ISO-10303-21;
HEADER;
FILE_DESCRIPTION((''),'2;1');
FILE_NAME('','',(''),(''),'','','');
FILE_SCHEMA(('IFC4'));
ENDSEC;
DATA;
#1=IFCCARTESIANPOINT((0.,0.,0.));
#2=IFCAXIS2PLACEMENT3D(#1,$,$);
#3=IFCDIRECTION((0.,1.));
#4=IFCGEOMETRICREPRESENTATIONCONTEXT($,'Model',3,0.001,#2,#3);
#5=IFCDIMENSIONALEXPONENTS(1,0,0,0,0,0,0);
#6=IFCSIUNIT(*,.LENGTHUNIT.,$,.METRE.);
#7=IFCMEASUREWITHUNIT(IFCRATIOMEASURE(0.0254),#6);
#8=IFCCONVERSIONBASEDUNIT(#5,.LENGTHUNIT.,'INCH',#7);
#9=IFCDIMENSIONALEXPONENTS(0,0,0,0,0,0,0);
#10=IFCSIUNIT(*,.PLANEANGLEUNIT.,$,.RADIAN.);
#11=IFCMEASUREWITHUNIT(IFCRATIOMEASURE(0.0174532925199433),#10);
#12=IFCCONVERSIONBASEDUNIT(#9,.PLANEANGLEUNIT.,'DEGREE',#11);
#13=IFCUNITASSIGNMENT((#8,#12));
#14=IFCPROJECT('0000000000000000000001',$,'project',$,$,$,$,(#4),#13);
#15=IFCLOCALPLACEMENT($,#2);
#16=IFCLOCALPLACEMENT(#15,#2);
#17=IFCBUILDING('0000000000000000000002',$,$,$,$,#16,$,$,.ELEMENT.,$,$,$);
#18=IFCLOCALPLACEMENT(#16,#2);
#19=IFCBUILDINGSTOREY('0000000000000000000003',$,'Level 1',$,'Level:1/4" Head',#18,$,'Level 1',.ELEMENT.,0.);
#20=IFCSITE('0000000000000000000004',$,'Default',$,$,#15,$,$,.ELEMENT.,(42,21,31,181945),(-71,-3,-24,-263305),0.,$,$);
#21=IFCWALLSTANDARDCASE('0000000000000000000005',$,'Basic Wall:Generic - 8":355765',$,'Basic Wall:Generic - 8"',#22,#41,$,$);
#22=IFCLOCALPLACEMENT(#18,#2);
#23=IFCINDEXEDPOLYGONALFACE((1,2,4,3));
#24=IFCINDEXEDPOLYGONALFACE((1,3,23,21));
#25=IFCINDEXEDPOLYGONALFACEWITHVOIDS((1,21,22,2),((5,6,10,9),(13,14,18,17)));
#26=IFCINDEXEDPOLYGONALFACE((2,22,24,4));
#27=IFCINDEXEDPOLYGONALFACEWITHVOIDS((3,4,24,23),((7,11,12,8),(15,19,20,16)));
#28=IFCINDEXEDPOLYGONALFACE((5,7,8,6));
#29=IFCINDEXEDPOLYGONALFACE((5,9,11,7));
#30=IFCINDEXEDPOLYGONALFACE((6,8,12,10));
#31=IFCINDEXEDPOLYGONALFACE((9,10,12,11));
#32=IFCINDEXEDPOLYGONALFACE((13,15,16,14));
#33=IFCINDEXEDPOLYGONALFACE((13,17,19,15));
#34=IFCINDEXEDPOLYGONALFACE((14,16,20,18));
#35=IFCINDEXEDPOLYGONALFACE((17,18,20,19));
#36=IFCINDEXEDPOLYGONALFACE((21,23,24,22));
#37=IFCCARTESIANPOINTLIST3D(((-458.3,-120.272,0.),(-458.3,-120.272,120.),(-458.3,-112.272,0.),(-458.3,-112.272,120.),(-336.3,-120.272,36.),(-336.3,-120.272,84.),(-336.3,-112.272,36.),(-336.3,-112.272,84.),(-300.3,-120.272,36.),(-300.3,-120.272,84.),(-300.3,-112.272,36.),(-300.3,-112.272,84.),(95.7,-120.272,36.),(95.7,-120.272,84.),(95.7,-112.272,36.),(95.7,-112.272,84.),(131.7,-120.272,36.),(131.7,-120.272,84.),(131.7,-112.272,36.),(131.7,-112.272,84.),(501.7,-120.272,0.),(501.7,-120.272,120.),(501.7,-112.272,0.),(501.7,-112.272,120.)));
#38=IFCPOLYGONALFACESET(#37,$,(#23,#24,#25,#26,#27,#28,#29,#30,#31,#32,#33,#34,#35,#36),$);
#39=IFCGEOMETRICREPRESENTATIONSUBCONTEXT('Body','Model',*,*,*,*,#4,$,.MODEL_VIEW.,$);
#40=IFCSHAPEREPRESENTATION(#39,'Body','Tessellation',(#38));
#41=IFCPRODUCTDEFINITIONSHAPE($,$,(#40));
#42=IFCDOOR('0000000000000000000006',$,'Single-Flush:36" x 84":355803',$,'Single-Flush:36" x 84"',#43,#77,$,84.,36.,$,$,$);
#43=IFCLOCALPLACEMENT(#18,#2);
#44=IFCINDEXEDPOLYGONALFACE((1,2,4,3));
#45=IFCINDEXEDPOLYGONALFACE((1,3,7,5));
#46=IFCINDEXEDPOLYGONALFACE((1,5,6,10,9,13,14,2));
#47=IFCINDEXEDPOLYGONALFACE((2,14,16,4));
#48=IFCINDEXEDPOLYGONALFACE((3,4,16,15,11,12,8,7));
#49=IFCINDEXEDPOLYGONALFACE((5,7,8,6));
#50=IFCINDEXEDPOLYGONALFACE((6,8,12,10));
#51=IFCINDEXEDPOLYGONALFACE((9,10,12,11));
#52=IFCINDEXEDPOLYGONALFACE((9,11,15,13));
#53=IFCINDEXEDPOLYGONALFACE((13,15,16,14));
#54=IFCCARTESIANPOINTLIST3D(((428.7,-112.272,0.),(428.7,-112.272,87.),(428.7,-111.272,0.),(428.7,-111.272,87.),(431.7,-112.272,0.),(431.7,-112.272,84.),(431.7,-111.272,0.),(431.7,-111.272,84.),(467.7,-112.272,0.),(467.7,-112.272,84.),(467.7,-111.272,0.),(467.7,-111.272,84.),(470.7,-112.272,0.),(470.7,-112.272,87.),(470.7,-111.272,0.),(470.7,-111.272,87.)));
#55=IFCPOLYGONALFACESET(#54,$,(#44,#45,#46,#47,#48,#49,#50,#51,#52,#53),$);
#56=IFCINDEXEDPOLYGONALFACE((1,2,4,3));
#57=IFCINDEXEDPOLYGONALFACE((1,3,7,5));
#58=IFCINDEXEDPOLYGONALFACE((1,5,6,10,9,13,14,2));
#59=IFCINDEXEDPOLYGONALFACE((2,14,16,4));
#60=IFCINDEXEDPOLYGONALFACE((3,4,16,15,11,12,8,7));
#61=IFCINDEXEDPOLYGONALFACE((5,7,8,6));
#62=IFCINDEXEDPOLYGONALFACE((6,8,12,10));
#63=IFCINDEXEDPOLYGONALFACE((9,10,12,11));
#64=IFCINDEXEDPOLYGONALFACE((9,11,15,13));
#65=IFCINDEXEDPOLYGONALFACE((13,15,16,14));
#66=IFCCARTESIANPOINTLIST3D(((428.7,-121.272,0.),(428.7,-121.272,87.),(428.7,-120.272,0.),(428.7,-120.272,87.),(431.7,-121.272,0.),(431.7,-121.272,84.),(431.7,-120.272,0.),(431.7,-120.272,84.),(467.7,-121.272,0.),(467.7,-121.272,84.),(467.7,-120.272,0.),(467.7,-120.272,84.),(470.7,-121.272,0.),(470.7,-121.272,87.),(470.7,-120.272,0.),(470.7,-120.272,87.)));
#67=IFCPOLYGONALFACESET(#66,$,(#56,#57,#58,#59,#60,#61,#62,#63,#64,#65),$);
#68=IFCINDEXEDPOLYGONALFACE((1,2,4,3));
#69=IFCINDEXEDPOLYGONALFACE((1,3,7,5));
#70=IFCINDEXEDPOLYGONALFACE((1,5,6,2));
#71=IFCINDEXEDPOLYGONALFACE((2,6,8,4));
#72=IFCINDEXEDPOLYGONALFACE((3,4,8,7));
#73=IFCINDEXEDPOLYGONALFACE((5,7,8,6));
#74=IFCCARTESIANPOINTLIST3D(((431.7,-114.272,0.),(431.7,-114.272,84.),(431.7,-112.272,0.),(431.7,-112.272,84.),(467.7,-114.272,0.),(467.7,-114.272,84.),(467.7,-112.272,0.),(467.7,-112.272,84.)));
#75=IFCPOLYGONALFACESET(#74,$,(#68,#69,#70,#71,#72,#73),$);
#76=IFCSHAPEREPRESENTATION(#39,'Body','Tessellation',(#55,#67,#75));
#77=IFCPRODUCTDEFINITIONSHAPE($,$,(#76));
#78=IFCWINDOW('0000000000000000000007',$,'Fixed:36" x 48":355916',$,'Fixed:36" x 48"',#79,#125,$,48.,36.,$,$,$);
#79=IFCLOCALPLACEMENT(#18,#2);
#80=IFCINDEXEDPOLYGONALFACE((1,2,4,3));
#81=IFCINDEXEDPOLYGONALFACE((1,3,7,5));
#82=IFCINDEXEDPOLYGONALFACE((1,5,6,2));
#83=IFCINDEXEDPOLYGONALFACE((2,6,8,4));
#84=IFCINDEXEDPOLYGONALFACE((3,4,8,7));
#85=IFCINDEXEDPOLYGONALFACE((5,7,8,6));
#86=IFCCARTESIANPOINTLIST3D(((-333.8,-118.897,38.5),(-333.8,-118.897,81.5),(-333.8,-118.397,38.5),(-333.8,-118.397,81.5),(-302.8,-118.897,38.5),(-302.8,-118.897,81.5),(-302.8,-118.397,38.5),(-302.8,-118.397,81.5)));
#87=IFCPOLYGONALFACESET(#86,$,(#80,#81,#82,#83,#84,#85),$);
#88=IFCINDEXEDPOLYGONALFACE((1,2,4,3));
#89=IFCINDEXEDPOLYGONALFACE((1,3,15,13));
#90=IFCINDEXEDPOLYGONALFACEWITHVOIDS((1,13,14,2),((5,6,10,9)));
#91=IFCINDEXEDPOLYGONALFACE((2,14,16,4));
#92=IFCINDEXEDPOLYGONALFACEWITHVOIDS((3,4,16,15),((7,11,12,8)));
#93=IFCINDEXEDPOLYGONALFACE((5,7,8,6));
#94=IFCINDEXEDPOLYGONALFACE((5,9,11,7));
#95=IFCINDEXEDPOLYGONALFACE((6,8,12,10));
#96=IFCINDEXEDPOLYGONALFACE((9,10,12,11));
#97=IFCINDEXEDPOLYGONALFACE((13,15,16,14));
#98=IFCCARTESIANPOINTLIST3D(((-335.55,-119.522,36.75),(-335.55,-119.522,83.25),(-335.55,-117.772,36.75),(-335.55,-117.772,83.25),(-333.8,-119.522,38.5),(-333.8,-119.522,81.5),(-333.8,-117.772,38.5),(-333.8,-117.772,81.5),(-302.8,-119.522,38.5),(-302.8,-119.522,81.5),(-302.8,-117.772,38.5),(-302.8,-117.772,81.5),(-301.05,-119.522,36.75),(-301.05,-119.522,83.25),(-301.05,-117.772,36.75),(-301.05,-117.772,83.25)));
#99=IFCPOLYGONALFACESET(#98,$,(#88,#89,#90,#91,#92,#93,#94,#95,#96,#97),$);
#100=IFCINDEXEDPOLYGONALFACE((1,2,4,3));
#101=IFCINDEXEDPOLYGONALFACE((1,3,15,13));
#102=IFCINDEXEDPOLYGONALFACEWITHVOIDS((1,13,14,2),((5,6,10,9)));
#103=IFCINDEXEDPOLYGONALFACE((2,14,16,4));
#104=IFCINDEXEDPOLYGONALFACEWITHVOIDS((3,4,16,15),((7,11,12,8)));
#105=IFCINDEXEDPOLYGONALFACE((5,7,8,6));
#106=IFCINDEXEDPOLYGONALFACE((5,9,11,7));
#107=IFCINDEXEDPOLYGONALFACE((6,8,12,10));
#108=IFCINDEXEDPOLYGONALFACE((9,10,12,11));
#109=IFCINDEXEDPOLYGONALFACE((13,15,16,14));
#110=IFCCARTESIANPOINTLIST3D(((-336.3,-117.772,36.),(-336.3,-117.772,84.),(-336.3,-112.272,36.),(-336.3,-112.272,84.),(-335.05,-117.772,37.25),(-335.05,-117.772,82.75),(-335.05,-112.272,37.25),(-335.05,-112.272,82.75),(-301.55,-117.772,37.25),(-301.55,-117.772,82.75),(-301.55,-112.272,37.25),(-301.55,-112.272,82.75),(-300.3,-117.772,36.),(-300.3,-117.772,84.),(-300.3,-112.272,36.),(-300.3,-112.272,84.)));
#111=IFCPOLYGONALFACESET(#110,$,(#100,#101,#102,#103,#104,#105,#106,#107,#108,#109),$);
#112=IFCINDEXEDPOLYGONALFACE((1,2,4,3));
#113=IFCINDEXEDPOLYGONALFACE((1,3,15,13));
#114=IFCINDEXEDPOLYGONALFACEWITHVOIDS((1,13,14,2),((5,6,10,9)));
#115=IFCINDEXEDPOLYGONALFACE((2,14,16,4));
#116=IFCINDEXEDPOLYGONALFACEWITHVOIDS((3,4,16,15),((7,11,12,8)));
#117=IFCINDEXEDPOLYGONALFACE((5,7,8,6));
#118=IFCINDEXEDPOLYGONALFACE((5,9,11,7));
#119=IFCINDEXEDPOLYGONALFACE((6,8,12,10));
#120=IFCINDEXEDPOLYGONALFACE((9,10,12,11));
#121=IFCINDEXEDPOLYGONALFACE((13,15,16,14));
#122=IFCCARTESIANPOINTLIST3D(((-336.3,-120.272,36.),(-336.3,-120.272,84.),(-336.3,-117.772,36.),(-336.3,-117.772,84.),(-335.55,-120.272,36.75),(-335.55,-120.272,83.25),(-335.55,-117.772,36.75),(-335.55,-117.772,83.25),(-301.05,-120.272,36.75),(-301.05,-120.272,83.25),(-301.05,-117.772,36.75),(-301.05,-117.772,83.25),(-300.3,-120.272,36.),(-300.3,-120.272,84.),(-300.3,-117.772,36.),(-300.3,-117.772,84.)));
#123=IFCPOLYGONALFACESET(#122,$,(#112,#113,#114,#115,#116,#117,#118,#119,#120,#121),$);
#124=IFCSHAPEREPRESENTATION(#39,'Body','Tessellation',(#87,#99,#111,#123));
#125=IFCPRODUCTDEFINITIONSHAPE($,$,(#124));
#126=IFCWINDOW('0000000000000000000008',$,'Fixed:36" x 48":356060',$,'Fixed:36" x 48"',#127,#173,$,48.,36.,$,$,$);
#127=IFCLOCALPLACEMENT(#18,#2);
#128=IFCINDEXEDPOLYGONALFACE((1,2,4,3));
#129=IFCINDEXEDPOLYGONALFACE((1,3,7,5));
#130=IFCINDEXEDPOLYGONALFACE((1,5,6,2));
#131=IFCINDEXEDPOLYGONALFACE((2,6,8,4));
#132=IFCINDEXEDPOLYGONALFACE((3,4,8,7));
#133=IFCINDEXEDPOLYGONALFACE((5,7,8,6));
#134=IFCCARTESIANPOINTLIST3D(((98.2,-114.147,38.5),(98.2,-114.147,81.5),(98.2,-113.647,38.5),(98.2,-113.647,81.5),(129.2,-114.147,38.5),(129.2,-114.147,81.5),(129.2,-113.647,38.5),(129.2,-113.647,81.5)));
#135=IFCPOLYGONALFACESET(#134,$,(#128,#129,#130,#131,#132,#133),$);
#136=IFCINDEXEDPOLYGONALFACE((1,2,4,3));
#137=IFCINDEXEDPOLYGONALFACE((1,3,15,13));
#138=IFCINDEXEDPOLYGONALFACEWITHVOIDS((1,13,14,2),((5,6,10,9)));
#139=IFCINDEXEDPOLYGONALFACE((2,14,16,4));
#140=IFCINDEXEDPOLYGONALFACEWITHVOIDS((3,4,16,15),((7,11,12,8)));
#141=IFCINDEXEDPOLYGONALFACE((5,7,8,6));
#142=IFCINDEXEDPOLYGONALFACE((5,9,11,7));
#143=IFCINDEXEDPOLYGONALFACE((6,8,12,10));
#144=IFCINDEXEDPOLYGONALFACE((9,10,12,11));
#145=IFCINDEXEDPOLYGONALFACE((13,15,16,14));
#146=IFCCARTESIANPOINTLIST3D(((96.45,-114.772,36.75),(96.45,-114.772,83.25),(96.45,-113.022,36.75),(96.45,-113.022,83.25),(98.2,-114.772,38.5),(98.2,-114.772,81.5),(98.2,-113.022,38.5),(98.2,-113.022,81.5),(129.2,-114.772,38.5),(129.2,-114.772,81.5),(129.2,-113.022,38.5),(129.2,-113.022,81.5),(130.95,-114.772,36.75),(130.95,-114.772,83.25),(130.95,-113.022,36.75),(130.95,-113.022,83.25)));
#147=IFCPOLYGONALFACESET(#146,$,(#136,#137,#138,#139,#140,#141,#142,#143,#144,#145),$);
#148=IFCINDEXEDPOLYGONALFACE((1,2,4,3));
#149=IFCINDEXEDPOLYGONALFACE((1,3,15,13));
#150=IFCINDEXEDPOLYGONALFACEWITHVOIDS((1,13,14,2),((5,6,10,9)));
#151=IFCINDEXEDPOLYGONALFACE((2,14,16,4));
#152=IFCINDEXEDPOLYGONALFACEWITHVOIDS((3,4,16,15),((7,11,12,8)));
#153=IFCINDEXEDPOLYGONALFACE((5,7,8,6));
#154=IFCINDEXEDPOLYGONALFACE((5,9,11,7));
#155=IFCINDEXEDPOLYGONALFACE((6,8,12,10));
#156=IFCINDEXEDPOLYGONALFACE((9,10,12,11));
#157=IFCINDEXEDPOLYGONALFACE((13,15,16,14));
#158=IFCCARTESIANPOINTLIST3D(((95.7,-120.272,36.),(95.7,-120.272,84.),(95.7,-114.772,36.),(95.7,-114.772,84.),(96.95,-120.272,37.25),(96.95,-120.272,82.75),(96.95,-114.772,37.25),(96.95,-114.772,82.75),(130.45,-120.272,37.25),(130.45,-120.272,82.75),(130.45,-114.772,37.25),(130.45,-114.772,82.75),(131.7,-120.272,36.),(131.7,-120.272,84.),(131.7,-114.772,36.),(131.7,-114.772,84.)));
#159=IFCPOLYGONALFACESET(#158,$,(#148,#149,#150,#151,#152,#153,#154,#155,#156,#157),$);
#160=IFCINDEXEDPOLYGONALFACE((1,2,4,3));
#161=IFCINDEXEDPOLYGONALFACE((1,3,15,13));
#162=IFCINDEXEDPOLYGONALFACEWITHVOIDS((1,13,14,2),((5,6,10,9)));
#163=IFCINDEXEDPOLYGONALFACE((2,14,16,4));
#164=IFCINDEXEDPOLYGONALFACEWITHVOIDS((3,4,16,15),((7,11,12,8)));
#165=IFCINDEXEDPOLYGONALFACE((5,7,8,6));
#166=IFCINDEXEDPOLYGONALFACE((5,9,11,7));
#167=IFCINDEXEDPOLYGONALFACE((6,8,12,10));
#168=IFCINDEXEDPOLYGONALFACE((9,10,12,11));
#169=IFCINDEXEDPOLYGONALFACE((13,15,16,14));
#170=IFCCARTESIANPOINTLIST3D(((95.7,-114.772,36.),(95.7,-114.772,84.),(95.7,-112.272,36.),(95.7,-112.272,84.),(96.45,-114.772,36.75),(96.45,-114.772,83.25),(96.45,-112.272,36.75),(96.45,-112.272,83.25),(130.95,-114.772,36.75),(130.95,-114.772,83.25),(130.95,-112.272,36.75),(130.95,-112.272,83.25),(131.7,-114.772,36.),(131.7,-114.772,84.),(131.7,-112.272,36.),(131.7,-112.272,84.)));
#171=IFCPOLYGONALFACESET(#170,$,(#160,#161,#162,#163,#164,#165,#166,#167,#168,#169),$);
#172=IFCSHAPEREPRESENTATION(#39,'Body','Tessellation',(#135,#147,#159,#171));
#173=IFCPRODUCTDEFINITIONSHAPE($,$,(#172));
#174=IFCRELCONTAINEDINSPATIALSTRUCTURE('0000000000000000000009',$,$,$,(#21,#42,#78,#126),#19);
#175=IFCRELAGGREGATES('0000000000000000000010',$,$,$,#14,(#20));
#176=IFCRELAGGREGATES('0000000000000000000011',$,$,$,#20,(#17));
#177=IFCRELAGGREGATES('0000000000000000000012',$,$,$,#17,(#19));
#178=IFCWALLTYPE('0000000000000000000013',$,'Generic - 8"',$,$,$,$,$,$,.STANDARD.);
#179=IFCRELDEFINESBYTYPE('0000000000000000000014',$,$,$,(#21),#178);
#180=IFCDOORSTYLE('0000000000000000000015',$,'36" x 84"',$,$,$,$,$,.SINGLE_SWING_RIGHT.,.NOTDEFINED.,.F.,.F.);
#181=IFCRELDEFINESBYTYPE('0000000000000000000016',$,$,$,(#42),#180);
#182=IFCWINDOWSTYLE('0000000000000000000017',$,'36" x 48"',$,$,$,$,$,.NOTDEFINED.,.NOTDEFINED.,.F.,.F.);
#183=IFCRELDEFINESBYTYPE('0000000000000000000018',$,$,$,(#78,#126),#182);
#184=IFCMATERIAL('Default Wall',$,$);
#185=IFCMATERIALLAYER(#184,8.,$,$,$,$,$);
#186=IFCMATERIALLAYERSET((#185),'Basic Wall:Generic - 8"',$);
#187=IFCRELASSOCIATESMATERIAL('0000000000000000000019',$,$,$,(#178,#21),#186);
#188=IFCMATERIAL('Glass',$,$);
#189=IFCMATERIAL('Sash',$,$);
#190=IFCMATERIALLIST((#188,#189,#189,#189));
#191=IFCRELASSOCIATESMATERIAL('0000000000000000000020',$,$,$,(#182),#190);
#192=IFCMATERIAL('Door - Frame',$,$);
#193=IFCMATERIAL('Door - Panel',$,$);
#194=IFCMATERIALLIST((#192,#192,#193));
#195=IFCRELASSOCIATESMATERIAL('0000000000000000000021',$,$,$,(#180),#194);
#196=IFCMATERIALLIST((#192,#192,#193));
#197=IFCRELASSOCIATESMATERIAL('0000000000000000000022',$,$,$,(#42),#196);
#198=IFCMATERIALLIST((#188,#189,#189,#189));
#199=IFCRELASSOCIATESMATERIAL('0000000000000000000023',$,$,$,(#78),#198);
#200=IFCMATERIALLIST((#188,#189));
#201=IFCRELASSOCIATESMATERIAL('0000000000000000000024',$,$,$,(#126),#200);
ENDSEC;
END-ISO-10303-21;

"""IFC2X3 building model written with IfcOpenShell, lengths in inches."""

from ifc_helpers import new_model, entity, si_unit, converted_unit, direction, frame, frame_2d, origin, place, context, subcontext, project, spatial, polyline, rectangle, outline, extrude, source, transform, mapped, material, material_list, layer, layer_set, layer_usage, type_object, type_shapes, element, fill, save


model = new_model("IFC2X3")

# Units and contexts
model_context = context("Model", 3, precision=0.001, world=origin(), true_north=direction((0.0, 1.0)))
body_context = subcontext(model_context, "Body", "Model", "MODEL_VIEW")
ifc_project = project(units=[converted_unit("LENGTHUNIT", "INCH", entity("IfcRatioMeasure", 0.0254), si_unit("LENGTHUNIT", "METRE"), dimensions=[1, 0, 0, 0, 0, 0, 0]), converted_unit("PLANEANGLEUNIT", "DEGREE", entity("IfcRatioMeasure", 0.0174532925199433), si_unit("PLANEANGLEUNIT", "RADIAN"), dimensions=[0, 0, 0, 0, 0, 0, 0])], contexts=[model_context])

# Site, building, storey
site_placement = place(None, origin())
site = spatial("IfcSite", under=ifc_project, at=site_placement, Name="Default", CompositionType="ELEMENT", RefLatitude=(42, 21, 31, 181945), RefLongitude=(-71, -3, -24, -263305), RefElevation=0.0)
building_placement = place(site_placement, origin())
building = spatial("IfcBuilding", under=site, at=building_placement, CompositionType="ELEMENT")
storey_placement = place(building_placement, origin())
storey = spatial("IfcBuildingStorey", under=building, at=storey_placement, Name="Level 1", ObjectType="Level:1/4\" Head", LongName="Level 1", CompositionType="ELEMENT", Elevation=0.0)

# Shared definitions
ifc_material_1 = material(Name="Default Wall")
ifc_layer_1 = layer(ifc_material_1, 8.0)
ifc_layer_set_1 = layer_set([ifc_layer_1], Name="Basic Wall:Generic - 8\"")
wall_type_1 = type_object("IfcWallType", Name="Generic - 8\"", PredefinedType="STANDARD", material=ifc_layer_set_1)
ifc_material_2 = material(Name="Glass")
ifc_material_3 = material(Name="Sash")
ifc_material_list_1 = material_list([ifc_material_2, ifc_material_3, ifc_material_3, ifc_material_3])
window_style = type_object("IfcWindowStyle", Name="36\" x 48\"", ConstructionType="NOTDEFINED", OperationType="NOTDEFINED", ParameterTakesPrecedence=False, Sizeable=False, material=ifc_material_list_1)
shared_shape_1 = source(origin(), body_context, "Body", "SweptSolid", [
    extrude(rectangle(XDim=0.5, YDim=31.0, at=frame_2d((0.0, 0.0), x_axis=(1.0, 0.0))), frame((18.0, 6.375, 2.5), z_axis=(0.0, 0.0, 1.0), x_axis=(0.0, 1.0, 0.0)), (0.0, 0.0, 1.0), 43.0),
    extrude(outline(polyline([(-17.25, -23.25), (17.25, -23.25), (17.25, 23.25), (-17.25, 23.25), (-17.25, -23.25)]), holes=[polyline([(-15.5, -21.5), (-15.5, 21.5), (15.5, 21.5), (15.5, -21.5), (-15.5, -21.5)])]), frame((18.0, 5.5, 24.0), z_axis=(0.0, 1.0, 0.0), x_axis=(1.0, 0.0, 0.0)), (0.0, 0.0, 1.0), 1.75),
    extrude(outline(polyline([(-18.0, -24.0), (18.0, -24.0), (18.0, 24.0), (-18.0, 24.0), (-18.0, -24.0)]), holes=[polyline([(-16.75, -22.75), (-16.75, 22.75), (16.75, 22.75), (16.75, -22.75), (-16.75, -22.75)])]), frame((18.0, 0.0, 24.0), z_axis=(0.0, 1.0, 0.0), x_axis=(1.0, 0.0, 0.0)), (0.0, 0.0, 1.0), 5.5),
    extrude(outline(polyline([(-24.0, -18.0), (24.0, -18.0), (24.0, 18.0), (-24.0, 18.0), (-24.0, -18.0)]), holes=[polyline([(-23.25, -17.25), (-23.25, 17.25), (23.25, 17.25), (23.25, -17.25), (-23.25, -17.25)])]), frame((18.0, 5.5, 24.0), z_axis=(0.0, 1.0, 0.0), x_axis=(0.0, 0.0, -1.0)), (0.0, 0.0, 1.0), 2.5),
])
type_shapes(window_style, [shared_shape_1])

# Wall, openings, door, windows
ifc_layer_usage_1 = layer_usage(ifc_layer_set_1, "AXIS2", "NEGATIVE", 4.0)
wall_1_placement = place(storey_placement, frame((501.7, -116.272, 0.0), z_axis=(0.0, 0.0, 1.0), x_axis=(-1.0, 0.0, 0.0)))
wall_1 = element("IfcWallStandardCase", 1, at=wall_1_placement, inside=storey, type_object=wall_type_1, material=ifc_layer_usage_1, Name="Basic Wall:Generic - 8\":355765", ObjectType="Basic Wall:Generic - 8\"", context=body_context, shape_type="SweptSolid", body=[
    extrude(rectangle(XDim=960.0, YDim=8.0, at=frame_2d((480.0, 0.0), x_axis=(-1.0, 0.0))), origin(), (0.0, 0.0, 1.0), 120.0),
])
opening_1_placement = place(wall_1_placement, frame((70.0, 12.0, 0.0)))
opening_1 = element("IfcOpeningElement", 2, at=opening_1_placement, cuts=wall_1, ObjectType="Opening", context=body_context, shape_type="SweptSolid", body=[
    extrude(rectangle(XDim=36.0, YDim=84.0, at=frame_2d((42.0, 18.0), x_axis=(0.0, 1.0))), frame((0.0, 0.0, 0.0), z_axis=(0.0, -1.0, 0.0), x_axis=(0.0, 0.0, 1.0)), (0.0, 0.0, 1.0), 8.0),
])
opening_2_placement = place(wall_1_placement, frame((838.0, 4.0, 36.0)))
opening_2 = element("IfcOpeningElement", 3, at=opening_2_placement, cuts=wall_1, ObjectType="Opening", context=body_context, shape_type="SweptSolid", body=[
    extrude(rectangle(XDim=48.0, YDim=36.0, at=frame_2d((24.0, 18.0), x_axis=(-1.0, 0.0))), frame((0.0, 0.0, 0.0), z_axis=(0.0, -1.0, 0.0), x_axis=(0.0, 0.0, 1.0)), (0.0, 0.0, 1.0), 8.0),
])
opening_3_placement = place(wall_1_placement, frame((406.0, 4.0, 36.0)))
opening_3 = element("IfcOpeningElement", 4, at=opening_3_placement, cuts=wall_1, ObjectType="Opening", context=body_context, shape_type="SweptSolid", body=[
    extrude(rectangle(XDim=48.0, YDim=36.0, at=frame_2d((24.0, 18.0), x_axis=(-1.0, 0.0))), frame((0.0, 0.0, 0.0), z_axis=(0.0, -1.0, 0.0), x_axis=(0.0, 0.0, 1.0)), (0.0, 0.0, 1.0), 8.0),
])
ifc_material_4 = material(Name="Door - Frame")
ifc_material_5 = material(Name="Door - Panel")
ifc_material_list_2 = material_list([ifc_material_4, ifc_material_4, ifc_material_5])
ifc_material_list_3 = material_list([ifc_material_4, ifc_material_4, ifc_material_5])
door_style_1 = type_object("IfcDoorStyle", Name="36\" x 84\"", ConstructionType="NOTDEFINED", OperationType="SINGLE_SWING_RIGHT", ParameterTakesPrecedence=False, Sizeable=False, material=ifc_material_list_3)
shared_shape_2 = source(origin(), body_context, "Body", "SweptSolid", [
    extrude(outline(polyline([(-21.0, -44.25), (21.0, -44.25), (21.0, 42.75), (18.0, 42.75), (18.0, -41.25), (-18.0, -41.25), (-18.0, 42.75), (-21.0, 42.75), (-21.0, -44.25)])), frame((18.0, 8.0, 42.75), z_axis=(0.0, 1.0, 0.0), x_axis=(1.0, 0.0, 0.0)), (0.0, 0.0, 1.0), 1.0),
    extrude(outline(polyline([(-44.25, -21.0), (42.75, -21.0), (42.75, -18.0), (-41.25, -18.0), (-41.25, 18.0), (42.75, 18.0), (42.75, 21.0), (-44.25, 21.0), (-44.25, -21.0)])), frame((18.0, -1.0, 42.75), z_axis=(0.0, 1.0, 0.0), x_axis=(0.0, 0.0, -1.0)), (0.0, 0.0, 1.0), 1.0),
    extrude(rectangle(XDim=2.0, YDim=36.0, at=frame_2d((0.0, 0.0), x_axis=(1.0, 0.0))), frame((18.0, 7.0, 0.0), z_axis=(0.0, 0.0, 1.0), x_axis=(0.0, 1.0, 0.0)), (0.0, 0.0, 1.0), 84.0),
])
type_shapes(door_style_1, [shared_shape_2])
door_1_placement = place(opening_1_placement, frame((0.0, -8.0, 0.0), z_axis=(0.0, 0.0, 1.0), x_axis=(-1.0, 0.0, 0.0)))
door_1 = element("IfcDoor", 5, at=door_1_placement, inside=storey, type_object=door_style_1, material=ifc_material_list_2, Name="Single-Flush:36\" x 84\":355803", ObjectType="Single-Flush:36\" x 84\"", OverallHeight=84.0, OverallWidth=36.0, context=body_context, shape_type="MappedRepresentation", body=[
    mapped(shared_shape_2, transform((0.0, 0.0, 0.0), scale=1.0)),
])
fill(opening_1, door_1)
ifc_material_list_4 = material_list([ifc_material_2, ifc_material_3, ifc_material_3, ifc_material_3])
window_1_placement = place(opening_2_placement, frame((-36.0, -8.0, 0.0)))
window_1 = element("IfcWindow", 6, at=window_1_placement, inside=storey, type_object=window_style, material=ifc_material_list_4, Name="Fixed:36\" x 48\":355916", ObjectType="Fixed:36\" x 48\"", OverallHeight=48.0, OverallWidth=36.0, context=body_context, shape_type="MappedRepresentation", body=[
    mapped(shared_shape_1, transform((0.0, 0.0, 0.0), scale=1.0)),
])
fill(opening_2, window_1)
ifc_material_list_5 = material_list([ifc_material_2, ifc_material_3])
window_2_placement = place(opening_3_placement, frame((0.0, 0.0, 0.0), z_axis=(0.0, 0.0, 1.0), x_axis=(-1.0, 0.0, 0.0)))
window_2 = element("IfcWindow", 7, at=window_2_placement, inside=storey, type_object=window_style, material=ifc_material_list_5, Name="Fixed:36\" x 48\":356060", ObjectType="Fixed:36\" x 48\"", OverallHeight=48.0, OverallWidth=36.0, context=body_context, shape_type="MappedRepresentation", body=[
    mapped(shared_shape_1, transform((0.0, 0.0, 0.0), scale=1.0)),
])
fill(opening_3, window_2)

save(model, "model.ifc")
